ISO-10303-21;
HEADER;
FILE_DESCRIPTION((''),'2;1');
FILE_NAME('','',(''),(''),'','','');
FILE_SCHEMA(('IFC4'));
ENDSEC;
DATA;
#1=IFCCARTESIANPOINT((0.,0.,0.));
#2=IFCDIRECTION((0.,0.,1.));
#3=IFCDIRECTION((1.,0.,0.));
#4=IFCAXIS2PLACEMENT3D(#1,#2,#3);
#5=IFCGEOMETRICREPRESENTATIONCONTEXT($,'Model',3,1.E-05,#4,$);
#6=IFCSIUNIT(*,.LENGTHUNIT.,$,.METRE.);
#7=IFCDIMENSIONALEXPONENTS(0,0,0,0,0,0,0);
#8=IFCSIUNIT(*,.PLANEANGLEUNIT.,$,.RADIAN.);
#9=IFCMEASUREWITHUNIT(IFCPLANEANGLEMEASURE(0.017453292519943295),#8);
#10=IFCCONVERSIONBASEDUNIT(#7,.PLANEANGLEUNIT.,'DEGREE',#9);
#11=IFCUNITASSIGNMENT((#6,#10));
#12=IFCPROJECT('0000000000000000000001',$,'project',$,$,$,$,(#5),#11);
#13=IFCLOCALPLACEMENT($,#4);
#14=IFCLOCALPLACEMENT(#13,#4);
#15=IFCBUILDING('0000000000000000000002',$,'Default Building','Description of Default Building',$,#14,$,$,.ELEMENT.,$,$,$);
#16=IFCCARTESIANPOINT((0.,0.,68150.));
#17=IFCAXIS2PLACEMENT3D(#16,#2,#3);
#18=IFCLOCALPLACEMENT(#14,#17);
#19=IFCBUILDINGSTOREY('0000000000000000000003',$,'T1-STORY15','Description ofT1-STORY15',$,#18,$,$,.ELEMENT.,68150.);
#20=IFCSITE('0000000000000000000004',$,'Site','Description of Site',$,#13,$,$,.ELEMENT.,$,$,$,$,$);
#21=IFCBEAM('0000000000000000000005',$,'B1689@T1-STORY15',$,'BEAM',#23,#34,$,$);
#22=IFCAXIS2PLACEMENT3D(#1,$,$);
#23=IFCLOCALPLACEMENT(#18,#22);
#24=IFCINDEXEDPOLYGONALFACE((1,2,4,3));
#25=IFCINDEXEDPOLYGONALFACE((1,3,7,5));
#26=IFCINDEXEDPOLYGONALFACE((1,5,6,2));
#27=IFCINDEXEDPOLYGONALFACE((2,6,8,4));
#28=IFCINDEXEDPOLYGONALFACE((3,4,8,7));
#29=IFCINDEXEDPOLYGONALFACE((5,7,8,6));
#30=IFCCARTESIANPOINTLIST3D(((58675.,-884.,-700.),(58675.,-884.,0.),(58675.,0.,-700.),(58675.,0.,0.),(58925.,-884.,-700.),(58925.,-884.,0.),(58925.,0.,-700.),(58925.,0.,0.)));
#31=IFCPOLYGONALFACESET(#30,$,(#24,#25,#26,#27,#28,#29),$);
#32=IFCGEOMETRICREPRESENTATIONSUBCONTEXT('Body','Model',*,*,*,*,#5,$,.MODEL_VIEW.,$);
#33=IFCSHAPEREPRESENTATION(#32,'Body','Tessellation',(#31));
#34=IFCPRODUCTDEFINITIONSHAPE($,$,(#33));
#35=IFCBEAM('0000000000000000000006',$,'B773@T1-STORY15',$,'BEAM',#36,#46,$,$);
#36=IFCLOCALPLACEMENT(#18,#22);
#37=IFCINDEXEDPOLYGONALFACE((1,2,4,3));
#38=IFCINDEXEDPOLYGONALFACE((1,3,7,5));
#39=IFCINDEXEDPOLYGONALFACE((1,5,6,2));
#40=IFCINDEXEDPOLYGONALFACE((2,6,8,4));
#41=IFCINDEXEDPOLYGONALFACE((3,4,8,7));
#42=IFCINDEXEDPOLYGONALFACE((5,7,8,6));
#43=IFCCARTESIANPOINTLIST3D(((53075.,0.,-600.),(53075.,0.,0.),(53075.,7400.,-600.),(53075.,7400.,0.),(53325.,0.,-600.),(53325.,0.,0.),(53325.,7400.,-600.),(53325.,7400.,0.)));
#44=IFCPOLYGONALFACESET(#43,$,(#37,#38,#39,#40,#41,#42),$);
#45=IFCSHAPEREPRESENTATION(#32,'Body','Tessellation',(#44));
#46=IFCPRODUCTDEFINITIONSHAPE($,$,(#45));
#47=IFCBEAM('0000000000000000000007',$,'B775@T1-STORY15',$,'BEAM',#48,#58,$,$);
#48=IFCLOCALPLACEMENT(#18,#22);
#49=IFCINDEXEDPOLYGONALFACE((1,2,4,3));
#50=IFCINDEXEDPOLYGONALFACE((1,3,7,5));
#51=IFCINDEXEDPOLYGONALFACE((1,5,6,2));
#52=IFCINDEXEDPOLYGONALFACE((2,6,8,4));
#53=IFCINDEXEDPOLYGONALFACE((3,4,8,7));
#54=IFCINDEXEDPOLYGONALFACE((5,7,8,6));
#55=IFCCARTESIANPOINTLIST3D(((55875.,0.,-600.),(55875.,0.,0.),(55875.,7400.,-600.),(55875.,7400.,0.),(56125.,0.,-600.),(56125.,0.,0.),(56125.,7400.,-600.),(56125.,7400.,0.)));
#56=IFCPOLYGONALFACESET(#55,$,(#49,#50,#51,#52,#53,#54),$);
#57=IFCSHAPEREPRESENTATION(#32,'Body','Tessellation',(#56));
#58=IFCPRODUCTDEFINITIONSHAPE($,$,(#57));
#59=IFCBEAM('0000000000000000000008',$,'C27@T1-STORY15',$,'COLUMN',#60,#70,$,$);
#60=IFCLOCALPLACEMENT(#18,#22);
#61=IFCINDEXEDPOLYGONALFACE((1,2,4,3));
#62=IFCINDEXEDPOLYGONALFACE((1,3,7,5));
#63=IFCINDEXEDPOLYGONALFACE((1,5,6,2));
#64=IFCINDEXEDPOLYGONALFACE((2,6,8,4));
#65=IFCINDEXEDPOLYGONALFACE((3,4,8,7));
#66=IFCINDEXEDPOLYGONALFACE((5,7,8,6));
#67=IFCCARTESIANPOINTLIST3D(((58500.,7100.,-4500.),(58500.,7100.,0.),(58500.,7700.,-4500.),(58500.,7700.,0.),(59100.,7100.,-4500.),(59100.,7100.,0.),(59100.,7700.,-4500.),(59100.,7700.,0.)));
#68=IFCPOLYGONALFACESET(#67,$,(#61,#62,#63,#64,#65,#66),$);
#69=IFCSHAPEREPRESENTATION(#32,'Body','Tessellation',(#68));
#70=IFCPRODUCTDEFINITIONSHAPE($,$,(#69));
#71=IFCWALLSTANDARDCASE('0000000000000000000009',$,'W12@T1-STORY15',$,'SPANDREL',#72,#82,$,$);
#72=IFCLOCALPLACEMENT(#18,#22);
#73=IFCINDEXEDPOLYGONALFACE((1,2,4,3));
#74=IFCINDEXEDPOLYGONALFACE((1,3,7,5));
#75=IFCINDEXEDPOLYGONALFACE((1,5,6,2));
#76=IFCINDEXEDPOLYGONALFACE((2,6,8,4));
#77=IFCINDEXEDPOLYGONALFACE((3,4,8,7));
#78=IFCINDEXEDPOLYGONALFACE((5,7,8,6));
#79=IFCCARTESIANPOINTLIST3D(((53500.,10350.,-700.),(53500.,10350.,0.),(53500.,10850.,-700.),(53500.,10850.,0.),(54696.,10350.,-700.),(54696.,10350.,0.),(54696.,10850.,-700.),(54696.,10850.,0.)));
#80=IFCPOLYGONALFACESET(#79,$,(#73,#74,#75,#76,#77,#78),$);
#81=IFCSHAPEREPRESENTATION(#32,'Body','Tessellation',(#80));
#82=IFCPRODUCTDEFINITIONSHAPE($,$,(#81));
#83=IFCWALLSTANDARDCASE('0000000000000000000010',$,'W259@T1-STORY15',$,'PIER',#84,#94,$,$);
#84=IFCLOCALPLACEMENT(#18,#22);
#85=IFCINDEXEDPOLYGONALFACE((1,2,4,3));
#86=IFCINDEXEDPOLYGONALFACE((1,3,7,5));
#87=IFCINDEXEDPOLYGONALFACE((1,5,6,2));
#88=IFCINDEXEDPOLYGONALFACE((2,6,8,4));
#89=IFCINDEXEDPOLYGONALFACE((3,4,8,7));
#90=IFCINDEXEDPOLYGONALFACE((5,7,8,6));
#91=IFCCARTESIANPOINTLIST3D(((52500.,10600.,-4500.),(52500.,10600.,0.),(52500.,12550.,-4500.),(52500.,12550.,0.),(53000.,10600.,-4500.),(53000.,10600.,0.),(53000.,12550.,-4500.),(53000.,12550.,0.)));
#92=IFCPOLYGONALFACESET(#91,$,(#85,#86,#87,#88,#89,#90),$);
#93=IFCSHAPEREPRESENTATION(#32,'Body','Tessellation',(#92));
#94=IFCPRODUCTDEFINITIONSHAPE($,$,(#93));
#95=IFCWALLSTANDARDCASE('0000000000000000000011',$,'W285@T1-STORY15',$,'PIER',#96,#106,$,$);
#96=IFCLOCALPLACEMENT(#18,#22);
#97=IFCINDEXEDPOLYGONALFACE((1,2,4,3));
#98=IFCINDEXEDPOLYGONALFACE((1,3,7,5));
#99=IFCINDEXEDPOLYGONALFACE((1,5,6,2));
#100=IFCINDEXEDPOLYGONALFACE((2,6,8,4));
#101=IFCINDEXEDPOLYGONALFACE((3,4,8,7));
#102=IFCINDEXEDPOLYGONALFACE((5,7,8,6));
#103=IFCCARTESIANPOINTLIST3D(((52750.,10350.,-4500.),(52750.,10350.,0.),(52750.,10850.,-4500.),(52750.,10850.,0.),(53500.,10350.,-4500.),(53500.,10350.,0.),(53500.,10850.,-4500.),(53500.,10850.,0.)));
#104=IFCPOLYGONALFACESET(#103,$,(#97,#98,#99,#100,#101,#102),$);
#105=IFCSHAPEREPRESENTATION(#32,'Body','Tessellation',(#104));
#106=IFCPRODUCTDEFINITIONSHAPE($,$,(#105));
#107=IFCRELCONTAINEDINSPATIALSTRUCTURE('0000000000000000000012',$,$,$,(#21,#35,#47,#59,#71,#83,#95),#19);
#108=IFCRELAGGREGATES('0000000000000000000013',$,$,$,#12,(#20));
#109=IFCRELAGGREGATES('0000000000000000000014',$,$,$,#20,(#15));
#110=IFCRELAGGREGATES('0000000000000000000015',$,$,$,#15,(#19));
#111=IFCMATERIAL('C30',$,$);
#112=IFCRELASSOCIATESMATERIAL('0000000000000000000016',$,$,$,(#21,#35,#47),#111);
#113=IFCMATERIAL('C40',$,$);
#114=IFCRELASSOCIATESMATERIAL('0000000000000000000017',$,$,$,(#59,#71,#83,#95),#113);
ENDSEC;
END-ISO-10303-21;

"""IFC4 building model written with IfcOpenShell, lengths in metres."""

from ifc_helpers import new_model, entity, si_unit, converted_unit, frame, origin_with_axes, place, context, subcontext, project, spatial, indexed_curve, rectangle, outline, extrude, material, element, save


model = new_model("IFC4")

# Units and contexts
model_context = context("Model", 3, precision=1e-05, world=origin_with_axes())
body_context = subcontext(model_context, "Body", "Model", "MODEL_VIEW")
ifc_project = project(units=[si_unit("LENGTHUNIT", "METRE"), converted_unit("PLANEANGLEUNIT", "DEGREE", entity("IfcPlaneAngleMeasure", 0.017453292519943295), si_unit("PLANEANGLEUNIT", "RADIAN"), dimensions=[0, 0, 0, 0, 0, 0, 0])], contexts=[model_context])

# Site, building, storey
site_placement = place(None, origin_with_axes())
site = spatial("IfcSite", under=ifc_project, at=site_placement, Name="Site", Description="Description of Site", CompositionType="ELEMENT")
building_placement = place(site_placement, origin_with_axes())
building = spatial("IfcBuilding", under=site, at=building_placement, Name="Default Building", Description="Description of Default Building", CompositionType="ELEMENT")
storey_placement = place(building_placement, frame((0.0, 0.0, 68150.0), z_axis=(0.0, 0.0, 1.0), x_axis=(1.0, 0.0, 0.0)))
storey = spatial("IfcBuildingStorey", under=building, at=storey_placement, Name="T1-STORY15", Description="Description ofT1-STORY15", CompositionType="ELEMENT", Elevation=68150.0)

# Beams
ifc_material_1 = material(Name="C30")
beam_1_placement = place(storey_placement, frame((58800.0, -884.0, -350.0), z_axis=(0.0, 1.0, 0.0), x_axis=(-1.0, 0.0, 0.0)))
element("IfcBeam", 1, at=beam_1_placement, inside=storey, material=ifc_material_1, Name="B1689@T1-STORY15", ObjectType="BEAM", context=body_context, shape_type="SweptSolid", body=[
    extrude(rectangle(XDim=250.0, YDim=700.0), origin_with_axes(), (0.0, 0.0, 1.0), 884.0),
])
for number, where, z_axis, x_axis, name in (
    (2, (53200.0, 0.0, -300.0), (0.0, 1.0, 0.0), (-1.0, 0.0, 0.0), "B773@T1-STORY15"),
    (3, (56000.0, 0.0, -300.0), (0.0, 1.0, 0.0), (-1.0, 0.0, 0.0), "B775@T1-STORY15"),
):
    element("IfcBeam", number, at=place(storey_placement, frame(where, z_axis=z_axis, x_axis=x_axis)), inside=storey, material=ifc_material_1, Name=name, ObjectType="BEAM", context=body_context, shape_type="SweptSolid", body=[
        extrude(rectangle(XDim=250.0, YDim=600.0), origin_with_axes(), (0.0, 0.0, 1.0), 7400.0),
    ])
ifc_material_2 = material(Name="C40")
beam_2_placement = place(storey_placement, frame((58800.0, 7400.0, -4500.0), z_axis=(0.0, 0.0, 1.0), x_axis=(-1.0, 0.0, 0.0)))
element("IfcBeam", 4, at=beam_2_placement, inside=storey, material=ifc_material_2, Name="C27@T1-STORY15", ObjectType="COLUMN", context=body_context, shape_type="SweptSolid", body=[
    extrude(rectangle(XDim=600.0, YDim=600.0), origin_with_axes(), (0.0, 0.0, 1.0), 4500.0),
])

# Walls
wall_1_placement = place(storey_placement, frame((53500.0, 10600.0, -700.0), z_axis=(0.0, 0.0, 1.0), x_axis=(1.0, 0.0, 0.0)))
element("IfcWallStandardCase", 5, at=wall_1_placement, inside=storey, material=ifc_material_2, Name="W12@T1-STORY15", ObjectType="SPANDREL", context=body_context, shape_type="SweptSolid", body=[
    extrude(outline(indexed_curve([(0.0, -250.0), (0.0, 250.0), (1196.0, 250.0), (1196.0, -250.0), (0.0, -250.0)], self_intersect=False)), origin_with_axes(), (0.0, 0.0, 1.0), 700.0),
])
wall_2_placement = place(storey_placement, frame((52750.0, 10600.0, -4500.0), z_axis=(0.0, 0.0, 1.0), x_axis=(0.0, 1.0, 0.0)))
element("IfcWallStandardCase", 6, at=wall_2_placement, inside=storey, material=ifc_material_2, Name="W259@T1-STORY15", ObjectType="PIER", context=body_context, shape_type="SweptSolid", body=[
    extrude(outline(indexed_curve([(0.0, -250.0), (0.0, 250.0), (1950.0, 250.0), (1950.0, -250.0), (0.0, -250.0)], self_intersect=False)), origin_with_axes(), (0.0, 0.0, 1.0), 4500.0),
])
wall_3_placement = place(storey_placement, frame((52750.0, 10600.0, -4500.0), z_axis=(0.0, 0.0, 1.0), x_axis=(1.0, 0.0, 0.0)))
element("IfcWallStandardCase", 7, at=wall_3_placement, inside=storey, material=ifc_material_2, Name="W285@T1-STORY15", ObjectType="PIER", context=body_context, shape_type="SweptSolid", body=[
    extrude(outline(indexed_curve([(0.0, -250.0), (0.0, 250.0), (750.0, 250.0), (750.0, -250.0), (0.0, -250.0)], self_intersect=False)), origin_with_axes(), (0.0, 0.0, 1.0), 4500.0),
])

save(model, "model.ifc")
